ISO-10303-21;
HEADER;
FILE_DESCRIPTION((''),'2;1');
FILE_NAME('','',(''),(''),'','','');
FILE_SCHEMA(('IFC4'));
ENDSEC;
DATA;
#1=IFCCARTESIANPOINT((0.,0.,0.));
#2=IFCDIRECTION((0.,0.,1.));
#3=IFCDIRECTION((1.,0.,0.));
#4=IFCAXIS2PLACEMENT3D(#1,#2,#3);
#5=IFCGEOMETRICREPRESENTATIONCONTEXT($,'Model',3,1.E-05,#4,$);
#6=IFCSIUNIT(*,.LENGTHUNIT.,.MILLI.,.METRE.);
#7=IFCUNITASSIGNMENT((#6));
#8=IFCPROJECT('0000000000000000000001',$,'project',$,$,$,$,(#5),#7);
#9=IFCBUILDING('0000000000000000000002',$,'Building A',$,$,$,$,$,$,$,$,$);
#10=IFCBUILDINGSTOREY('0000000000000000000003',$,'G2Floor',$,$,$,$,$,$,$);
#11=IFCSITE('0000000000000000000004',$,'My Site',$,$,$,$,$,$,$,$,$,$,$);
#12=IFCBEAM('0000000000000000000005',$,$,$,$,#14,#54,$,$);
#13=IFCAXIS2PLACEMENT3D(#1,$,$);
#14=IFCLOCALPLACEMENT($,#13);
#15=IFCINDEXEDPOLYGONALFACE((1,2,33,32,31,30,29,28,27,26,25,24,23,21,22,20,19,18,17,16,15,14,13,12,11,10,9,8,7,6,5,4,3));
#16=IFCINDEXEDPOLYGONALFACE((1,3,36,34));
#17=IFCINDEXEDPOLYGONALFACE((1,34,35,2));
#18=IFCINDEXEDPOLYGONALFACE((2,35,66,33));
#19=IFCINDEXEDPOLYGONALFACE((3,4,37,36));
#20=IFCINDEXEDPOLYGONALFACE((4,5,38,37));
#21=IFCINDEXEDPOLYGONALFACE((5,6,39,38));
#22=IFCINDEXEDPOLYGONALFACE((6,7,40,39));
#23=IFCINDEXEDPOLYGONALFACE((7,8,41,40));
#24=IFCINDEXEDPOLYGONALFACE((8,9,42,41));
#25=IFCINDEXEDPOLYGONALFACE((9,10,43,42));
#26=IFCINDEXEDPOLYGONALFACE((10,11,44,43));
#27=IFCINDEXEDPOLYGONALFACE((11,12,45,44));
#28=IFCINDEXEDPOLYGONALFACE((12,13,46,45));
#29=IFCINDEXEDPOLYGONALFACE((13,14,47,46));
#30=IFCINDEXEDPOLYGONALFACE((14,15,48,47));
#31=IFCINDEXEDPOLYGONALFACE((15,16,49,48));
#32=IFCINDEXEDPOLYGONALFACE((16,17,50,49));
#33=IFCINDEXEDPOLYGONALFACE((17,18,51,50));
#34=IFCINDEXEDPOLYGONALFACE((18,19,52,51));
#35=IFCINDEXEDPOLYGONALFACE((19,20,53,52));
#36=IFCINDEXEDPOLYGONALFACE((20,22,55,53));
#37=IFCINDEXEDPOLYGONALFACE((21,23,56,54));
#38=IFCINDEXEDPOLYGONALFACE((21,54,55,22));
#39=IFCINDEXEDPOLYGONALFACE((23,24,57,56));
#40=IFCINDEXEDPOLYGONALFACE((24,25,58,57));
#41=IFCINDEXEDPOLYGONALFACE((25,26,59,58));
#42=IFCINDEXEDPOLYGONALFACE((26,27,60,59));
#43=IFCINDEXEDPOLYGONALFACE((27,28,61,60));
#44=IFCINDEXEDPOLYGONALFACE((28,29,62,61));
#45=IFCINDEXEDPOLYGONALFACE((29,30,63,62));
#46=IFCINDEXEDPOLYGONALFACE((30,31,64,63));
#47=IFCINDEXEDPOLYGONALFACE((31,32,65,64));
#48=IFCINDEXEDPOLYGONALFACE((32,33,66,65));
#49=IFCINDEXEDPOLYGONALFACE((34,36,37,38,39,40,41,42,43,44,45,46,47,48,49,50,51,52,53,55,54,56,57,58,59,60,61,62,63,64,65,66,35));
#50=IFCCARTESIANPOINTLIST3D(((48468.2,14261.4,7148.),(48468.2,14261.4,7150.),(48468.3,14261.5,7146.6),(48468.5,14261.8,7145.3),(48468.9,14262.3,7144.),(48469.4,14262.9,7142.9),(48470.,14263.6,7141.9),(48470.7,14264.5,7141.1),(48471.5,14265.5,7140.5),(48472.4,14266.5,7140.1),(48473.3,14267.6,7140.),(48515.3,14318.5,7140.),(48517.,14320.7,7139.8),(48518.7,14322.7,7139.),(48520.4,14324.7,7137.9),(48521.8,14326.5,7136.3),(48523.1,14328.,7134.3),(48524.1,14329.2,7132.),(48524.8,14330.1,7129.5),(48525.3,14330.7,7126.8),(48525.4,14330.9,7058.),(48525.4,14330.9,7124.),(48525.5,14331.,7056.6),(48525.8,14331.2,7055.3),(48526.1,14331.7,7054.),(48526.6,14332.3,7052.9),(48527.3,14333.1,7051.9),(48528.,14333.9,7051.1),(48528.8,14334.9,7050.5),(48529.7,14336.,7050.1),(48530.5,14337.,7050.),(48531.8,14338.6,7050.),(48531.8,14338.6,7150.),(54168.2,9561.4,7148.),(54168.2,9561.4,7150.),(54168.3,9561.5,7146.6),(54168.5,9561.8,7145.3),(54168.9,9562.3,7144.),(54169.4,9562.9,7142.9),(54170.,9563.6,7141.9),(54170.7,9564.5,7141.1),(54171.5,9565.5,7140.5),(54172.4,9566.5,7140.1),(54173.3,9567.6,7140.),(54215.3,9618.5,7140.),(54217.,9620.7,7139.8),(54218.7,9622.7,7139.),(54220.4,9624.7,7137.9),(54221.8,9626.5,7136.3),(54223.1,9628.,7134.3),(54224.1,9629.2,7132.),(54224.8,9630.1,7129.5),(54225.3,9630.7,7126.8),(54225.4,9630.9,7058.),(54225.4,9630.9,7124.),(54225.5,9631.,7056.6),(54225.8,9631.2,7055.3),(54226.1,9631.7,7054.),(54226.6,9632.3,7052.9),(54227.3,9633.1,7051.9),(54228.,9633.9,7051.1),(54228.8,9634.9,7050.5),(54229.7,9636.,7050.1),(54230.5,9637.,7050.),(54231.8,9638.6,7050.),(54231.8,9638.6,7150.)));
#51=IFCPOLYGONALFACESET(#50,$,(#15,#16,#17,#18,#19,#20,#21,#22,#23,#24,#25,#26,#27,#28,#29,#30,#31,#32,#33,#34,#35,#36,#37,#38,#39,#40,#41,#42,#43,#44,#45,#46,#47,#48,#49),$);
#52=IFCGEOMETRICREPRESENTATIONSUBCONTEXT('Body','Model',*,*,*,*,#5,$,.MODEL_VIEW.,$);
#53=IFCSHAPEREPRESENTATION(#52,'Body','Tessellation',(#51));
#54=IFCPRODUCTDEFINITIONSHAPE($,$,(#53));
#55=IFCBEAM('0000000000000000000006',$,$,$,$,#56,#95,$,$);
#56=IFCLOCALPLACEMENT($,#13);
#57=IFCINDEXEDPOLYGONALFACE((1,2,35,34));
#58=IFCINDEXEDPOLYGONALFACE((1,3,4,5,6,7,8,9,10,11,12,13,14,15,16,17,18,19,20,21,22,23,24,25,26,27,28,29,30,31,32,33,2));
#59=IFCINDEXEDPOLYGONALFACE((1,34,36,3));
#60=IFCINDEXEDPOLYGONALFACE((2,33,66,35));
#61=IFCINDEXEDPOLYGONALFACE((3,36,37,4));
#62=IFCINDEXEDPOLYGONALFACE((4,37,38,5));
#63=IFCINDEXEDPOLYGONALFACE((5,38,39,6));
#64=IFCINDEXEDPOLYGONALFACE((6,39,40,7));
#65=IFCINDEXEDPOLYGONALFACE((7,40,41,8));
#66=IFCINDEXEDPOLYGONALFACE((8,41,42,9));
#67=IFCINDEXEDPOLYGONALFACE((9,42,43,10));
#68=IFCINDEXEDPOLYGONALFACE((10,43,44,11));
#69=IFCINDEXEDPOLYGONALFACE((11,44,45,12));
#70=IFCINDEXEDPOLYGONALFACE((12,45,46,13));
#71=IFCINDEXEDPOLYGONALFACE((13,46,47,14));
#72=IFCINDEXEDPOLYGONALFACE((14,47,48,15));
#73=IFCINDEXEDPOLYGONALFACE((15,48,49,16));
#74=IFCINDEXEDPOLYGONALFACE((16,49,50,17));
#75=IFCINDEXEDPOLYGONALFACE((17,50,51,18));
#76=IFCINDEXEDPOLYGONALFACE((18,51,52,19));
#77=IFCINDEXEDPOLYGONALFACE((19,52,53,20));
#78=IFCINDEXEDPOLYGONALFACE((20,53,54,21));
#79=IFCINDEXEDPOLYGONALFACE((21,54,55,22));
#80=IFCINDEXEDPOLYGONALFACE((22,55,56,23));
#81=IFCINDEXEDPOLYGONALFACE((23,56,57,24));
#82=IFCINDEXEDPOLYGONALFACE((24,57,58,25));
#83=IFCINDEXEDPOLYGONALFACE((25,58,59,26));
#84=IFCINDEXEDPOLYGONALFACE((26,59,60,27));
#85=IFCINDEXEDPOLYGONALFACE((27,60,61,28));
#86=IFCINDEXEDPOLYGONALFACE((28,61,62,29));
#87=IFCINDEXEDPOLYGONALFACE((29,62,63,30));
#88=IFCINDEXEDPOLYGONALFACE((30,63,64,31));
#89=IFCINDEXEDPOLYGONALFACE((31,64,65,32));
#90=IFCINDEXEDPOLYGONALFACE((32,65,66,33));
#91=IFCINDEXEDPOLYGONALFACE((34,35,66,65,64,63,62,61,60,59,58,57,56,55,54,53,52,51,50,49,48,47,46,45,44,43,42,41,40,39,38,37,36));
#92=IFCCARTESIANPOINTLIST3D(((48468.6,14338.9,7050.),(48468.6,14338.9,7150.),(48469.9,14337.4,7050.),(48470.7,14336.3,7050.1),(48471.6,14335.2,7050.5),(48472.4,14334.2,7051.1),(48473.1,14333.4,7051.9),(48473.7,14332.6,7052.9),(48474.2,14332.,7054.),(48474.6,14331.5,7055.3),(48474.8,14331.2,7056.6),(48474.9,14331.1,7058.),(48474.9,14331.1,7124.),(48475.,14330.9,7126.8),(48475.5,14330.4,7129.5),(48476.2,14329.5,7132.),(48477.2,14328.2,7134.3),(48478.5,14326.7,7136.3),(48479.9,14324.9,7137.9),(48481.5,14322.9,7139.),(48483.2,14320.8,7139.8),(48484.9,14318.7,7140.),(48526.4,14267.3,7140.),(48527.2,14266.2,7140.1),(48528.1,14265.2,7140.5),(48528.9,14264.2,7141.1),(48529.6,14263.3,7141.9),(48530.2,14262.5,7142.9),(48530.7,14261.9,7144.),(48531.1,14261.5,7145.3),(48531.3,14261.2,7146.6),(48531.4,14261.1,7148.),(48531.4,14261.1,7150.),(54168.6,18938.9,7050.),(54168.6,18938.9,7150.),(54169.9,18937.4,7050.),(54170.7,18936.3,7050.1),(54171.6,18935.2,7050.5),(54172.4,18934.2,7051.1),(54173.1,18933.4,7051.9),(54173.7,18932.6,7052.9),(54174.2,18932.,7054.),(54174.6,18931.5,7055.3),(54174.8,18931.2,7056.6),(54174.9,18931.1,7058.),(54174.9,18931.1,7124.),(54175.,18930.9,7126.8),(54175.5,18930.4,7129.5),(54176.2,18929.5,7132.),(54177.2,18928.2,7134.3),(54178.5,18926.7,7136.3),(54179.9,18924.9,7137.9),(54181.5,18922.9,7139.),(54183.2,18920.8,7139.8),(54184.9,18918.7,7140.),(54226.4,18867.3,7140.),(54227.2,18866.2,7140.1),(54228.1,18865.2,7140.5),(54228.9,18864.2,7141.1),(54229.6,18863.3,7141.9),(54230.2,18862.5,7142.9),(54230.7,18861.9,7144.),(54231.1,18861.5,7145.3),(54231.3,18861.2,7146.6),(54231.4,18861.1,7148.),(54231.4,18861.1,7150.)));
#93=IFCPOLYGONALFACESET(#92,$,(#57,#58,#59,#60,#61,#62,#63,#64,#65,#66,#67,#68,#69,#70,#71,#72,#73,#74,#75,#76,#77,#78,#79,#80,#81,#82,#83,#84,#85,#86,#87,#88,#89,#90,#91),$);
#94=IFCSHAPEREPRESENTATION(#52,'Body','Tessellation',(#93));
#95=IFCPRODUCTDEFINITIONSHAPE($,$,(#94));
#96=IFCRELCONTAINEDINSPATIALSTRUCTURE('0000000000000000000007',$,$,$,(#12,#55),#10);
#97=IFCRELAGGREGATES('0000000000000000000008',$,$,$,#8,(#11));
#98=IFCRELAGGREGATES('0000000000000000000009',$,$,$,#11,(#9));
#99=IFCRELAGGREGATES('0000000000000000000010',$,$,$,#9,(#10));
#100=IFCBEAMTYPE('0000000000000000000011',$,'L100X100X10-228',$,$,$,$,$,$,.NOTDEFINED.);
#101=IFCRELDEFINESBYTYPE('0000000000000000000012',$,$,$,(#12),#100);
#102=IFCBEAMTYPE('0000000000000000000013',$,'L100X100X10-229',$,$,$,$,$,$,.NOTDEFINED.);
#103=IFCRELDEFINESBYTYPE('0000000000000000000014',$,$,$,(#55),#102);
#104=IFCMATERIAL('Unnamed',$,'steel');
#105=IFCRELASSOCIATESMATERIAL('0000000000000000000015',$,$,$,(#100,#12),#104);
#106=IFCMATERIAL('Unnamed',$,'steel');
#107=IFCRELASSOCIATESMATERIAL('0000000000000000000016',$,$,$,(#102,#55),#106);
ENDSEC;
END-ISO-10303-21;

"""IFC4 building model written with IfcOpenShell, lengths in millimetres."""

from ifc_helpers import new_model, si_unit, frame, origin_with_axes, place, context, subcontext, project, spatial, polyline, outline, extrude, material, material_profile, profile_set, profile_usage, type_object, element, save


model = new_model("IFC4")

# Units and contexts
model_context = context("Model", 3, precision=1e-05, world=origin_with_axes())
body_context = subcontext(model_context, "Body", "Model", "MODEL_VIEW")
ifc_project = project(units=[si_unit("LENGTHUNIT", "METRE", prefix="MILLI")], contexts=[model_context])

# Site, building, storey
site = spatial("IfcSite", under=ifc_project, Name="My Site")
building = spatial("IfcBuilding", under=site, Name="Building A")
storey = spatial("IfcBuildingStorey", under=building, Name="G2Floor")

# Beams
ifc_material_1 = material(Name="Unnamed", Category="steel")
ifc_material_profile_1 = material_profile(ifc_material_1, outline(polyline([(-50.0, -50.0), (50.0, -50.0), (50.0, -50.0), (50.0, -48.0), (50.0, -48.0), (49.9, -46.6), (49.9, -46.6), (49.5, -45.3), (49.5, -45.3), (48.9, -44.0), (48.9, -44.0), (48.1, -42.9), (48.1, -42.9), (47.1, -41.9), (47.1, -41.9), (46.0, -41.1), (46.0, -41.1), (44.7, -40.5), (44.7, -40.5), (43.4, -40.1), (43.4, -40.1), (42.0, -40.0), (42.0, -40.0), (-24.0, -40.0), (-24.0, -40.0), (-26.8, -39.8), (-26.8, -39.8), (-29.5, -39.0), (-29.5, -39.0), (-32.0, -37.9), (-32.0, -37.9), (-34.3, -36.3), (-34.3, -36.3), (-36.3, -34.3), (-36.3, -34.3), (-37.9, -32.0), (-37.9, -32.0), (-39.0, -29.5), (-39.0, -29.5), (-39.8, -26.8), (-39.8, -26.8), (-40.0, -24.0), (-40.0, -24.0), (-40.0, 42.0), (-40.0, 42.0), (-40.1, 43.4), (-40.1, 43.4), (-40.5, 44.7), (-40.5, 44.7), (-41.1, 46.0), (-41.1, 46.0), (-41.9, 47.1), (-41.9, 47.1), (-42.9, 48.1), (-42.9, 48.1), (-44.0, 48.9), (-44.0, 48.9), (-45.3, 49.5), (-45.3, 49.5), (-46.6, 49.9), (-46.6, 49.9), (-48.0, 50.0), (-48.0, 50.0), (-50.0, 50.0), (-50.0, 50.0), (-50.0, -50.0)])))
ifc_profile_set_1 = profile_set([ifc_material_profile_1], Name="L100X100X10-228")
ifc_profile_usage_1 = profile_usage(ifc_profile_set_1)
beam_type_1 = type_object("IfcBeamType", Name="L100X100X10-228", PredefinedType="NOTDEFINED", material=ifc_profile_set_1)
beam_1_placement = place(None, frame((48500.0, 14300.0, 7100.0), z_axis=(0.771539, -0.636182, 0.0), x_axis=(-0.636182, -0.771539, 0.0)))
element("IfcBeam", 1, at=beam_1_placement, inside=storey, type_object=beam_type_1, material=ifc_profile_usage_1, context=body_context, shape_type="SweptSolid", body=[
    extrude(outline(polyline([(-50.0, -50.0), (50.0, -50.0), (50.0, -50.0), (50.0, -48.0), (50.0, -48.0), (49.9, -46.6), (49.9, -46.6), (49.5, -45.3), (49.5, -45.3), (48.9, -44.0), (48.9, -44.0), (48.1, -42.9), (48.1, -42.9), (47.1, -41.9), (47.1, -41.9), (46.0, -41.1), (46.0, -41.1), (44.7, -40.5), (44.7, -40.5), (43.4, -40.1), (43.4, -40.1), (42.0, -40.0), (42.0, -40.0), (-24.0, -40.0), (-24.0, -40.0), (-26.8, -39.8), (-26.8, -39.8), (-29.5, -39.0), (-29.5, -39.0), (-32.0, -37.9), (-32.0, -37.9), (-34.3, -36.3), (-34.3, -36.3), (-36.3, -34.3), (-36.3, -34.3), (-37.9, -32.0), (-37.9, -32.0), (-39.0, -29.5), (-39.0, -29.5), (-39.8, -26.8), (-39.8, -26.8), (-40.0, -24.0), (-40.0, -24.0), (-40.0, 42.0), (-40.0, 42.0), (-40.1, 43.4), (-40.1, 43.4), (-40.5, 44.7), (-40.5, 44.7), (-41.1, 46.0), (-41.1, 46.0), (-41.9, 47.1), (-41.9, 47.1), (-42.9, 48.1), (-42.9, 48.1), (-44.0, 48.9), (-44.0, 48.9), (-45.3, 49.5), (-45.3, 49.5), (-46.6, 49.9), (-46.6, 49.9), (-48.0, 50.0), (-48.0, 50.0), (-50.0, 50.0), (-50.0, 50.0), (-50.0, -50.0)])), origin_with_axes(), (0.0, 0.0, 1.0), 7387.8),
])
ifc_material_2 = material(Name="Unnamed", Category="steel")
ifc_material_profile_2 = material_profile(ifc_material_2, outline(polyline([(-50.0, -50.0), (50.0, -50.0), (50.0, -50.0), (50.0, -48.0), (50.0, -48.0), (49.9, -46.6), (49.9, -46.6), (49.5, -45.3), (49.5, -45.3), (48.9, -44.0), (48.9, -44.0), (48.1, -42.9), (48.1, -42.9), (47.1, -41.9), (47.1, -41.9), (46.0, -41.1), (46.0, -41.1), (44.7, -40.5), (44.7, -40.5), (43.4, -40.1), (43.4, -40.1), (42.0, -40.0), (42.0, -40.0), (-24.0, -40.0), (-24.0, -40.0), (-26.8, -39.8), (-26.8, -39.8), (-29.5, -39.0), (-29.5, -39.0), (-32.0, -37.9), (-32.0, -37.9), (-34.3, -36.3), (-34.3, -36.3), (-36.3, -34.3), (-36.3, -34.3), (-37.9, -32.0), (-37.9, -32.0), (-39.0, -29.5), (-39.0, -29.5), (-39.8, -26.8), (-39.8, -26.8), (-40.0, -24.0), (-40.0, -24.0), (-40.0, 42.0), (-40.0, 42.0), (-40.1, 43.4), (-40.1, 43.4), (-40.5, 44.7), (-40.5, 44.7), (-41.1, 46.0), (-41.1, 46.0), (-41.9, 47.1), (-41.9, 47.1), (-42.9, 48.1), (-42.9, 48.1), (-44.0, 48.9), (-44.0, 48.9), (-45.3, 49.5), (-45.3, 49.5), (-46.6, 49.9), (-46.6, 49.9), (-48.0, 50.0), (-48.0, 50.0), (-50.0, 50.0), (-50.0, 50.0), (-50.0, -50.0)])))
ifc_profile_set_2 = profile_set([ifc_material_profile_2], Name="L100X100X10-229")
ifc_profile_usage_2 = profile_usage(ifc_profile_set_2)
beam_type_2 = type_object("IfcBeamType", Name="L100X100X10-229", PredefinedType="NOTDEFINED", material=ifc_profile_set_2)
beam_2_placement = place(None, frame((48500.0, 14300.0, 7100.0), z_axis=(0.778198, 0.628019, 0.0), x_axis=(0.628019, -0.778198, 0.0)))
element("IfcBeam", 2, at=beam_2_placement, inside=storey, type_object=beam_type_2, material=ifc_profile_usage_2, context=body_context, shape_type="SweptSolid", body=[
    extrude(outline(polyline([(-50.0, -50.0), (50.0, -50.0), (50.0, -50.0), (50.0, -48.0), (50.0, -48.0), (49.9, -46.6), (49.9, -46.6), (49.5, -45.3), (49.5, -45.3), (48.9, -44.0), (48.9, -44.0), (48.1, -42.9), (48.1, -42.9), (47.1, -41.9), (47.1, -41.9), (46.0, -41.1), (46.0, -41.1), (44.7, -40.5), (44.7, -40.5), (43.4, -40.1), (43.4, -40.1), (42.0, -40.0), (42.0, -40.0), (-24.0, -40.0), (-24.0, -40.0), (-26.8, -39.8), (-26.8, -39.8), (-29.5, -39.0), (-29.5, -39.0), (-32.0, -37.9), (-32.0, -37.9), (-34.3, -36.3), (-34.3, -36.3), (-36.3, -34.3), (-36.3, -34.3), (-37.9, -32.0), (-37.9, -32.0), (-39.0, -29.5), (-39.0, -29.5), (-39.8, -26.8), (-39.8, -26.8), (-40.0, -24.0), (-40.0, -24.0), (-40.0, 42.0), (-40.0, 42.0), (-40.1, 43.4), (-40.1, 43.4), (-40.5, 44.7), (-40.5, 44.7), (-41.1, 46.0), (-41.1, 46.0), (-41.9, 47.1), (-41.9, 47.1), (-42.9, 48.1), (-42.9, 48.1), (-44.0, 48.9), (-44.0, 48.9), (-45.3, 49.5), (-45.3, 49.5), (-46.6, 49.9), (-46.6, 49.9), (-48.0, 50.0), (-48.0, 50.0), (-50.0, 50.0), (-50.0, 50.0), (-50.0, -50.0)])), origin_with_axes(), (0.0, 0.0, 1.0), 7324.6),
])

save(model, "model.ifc")
